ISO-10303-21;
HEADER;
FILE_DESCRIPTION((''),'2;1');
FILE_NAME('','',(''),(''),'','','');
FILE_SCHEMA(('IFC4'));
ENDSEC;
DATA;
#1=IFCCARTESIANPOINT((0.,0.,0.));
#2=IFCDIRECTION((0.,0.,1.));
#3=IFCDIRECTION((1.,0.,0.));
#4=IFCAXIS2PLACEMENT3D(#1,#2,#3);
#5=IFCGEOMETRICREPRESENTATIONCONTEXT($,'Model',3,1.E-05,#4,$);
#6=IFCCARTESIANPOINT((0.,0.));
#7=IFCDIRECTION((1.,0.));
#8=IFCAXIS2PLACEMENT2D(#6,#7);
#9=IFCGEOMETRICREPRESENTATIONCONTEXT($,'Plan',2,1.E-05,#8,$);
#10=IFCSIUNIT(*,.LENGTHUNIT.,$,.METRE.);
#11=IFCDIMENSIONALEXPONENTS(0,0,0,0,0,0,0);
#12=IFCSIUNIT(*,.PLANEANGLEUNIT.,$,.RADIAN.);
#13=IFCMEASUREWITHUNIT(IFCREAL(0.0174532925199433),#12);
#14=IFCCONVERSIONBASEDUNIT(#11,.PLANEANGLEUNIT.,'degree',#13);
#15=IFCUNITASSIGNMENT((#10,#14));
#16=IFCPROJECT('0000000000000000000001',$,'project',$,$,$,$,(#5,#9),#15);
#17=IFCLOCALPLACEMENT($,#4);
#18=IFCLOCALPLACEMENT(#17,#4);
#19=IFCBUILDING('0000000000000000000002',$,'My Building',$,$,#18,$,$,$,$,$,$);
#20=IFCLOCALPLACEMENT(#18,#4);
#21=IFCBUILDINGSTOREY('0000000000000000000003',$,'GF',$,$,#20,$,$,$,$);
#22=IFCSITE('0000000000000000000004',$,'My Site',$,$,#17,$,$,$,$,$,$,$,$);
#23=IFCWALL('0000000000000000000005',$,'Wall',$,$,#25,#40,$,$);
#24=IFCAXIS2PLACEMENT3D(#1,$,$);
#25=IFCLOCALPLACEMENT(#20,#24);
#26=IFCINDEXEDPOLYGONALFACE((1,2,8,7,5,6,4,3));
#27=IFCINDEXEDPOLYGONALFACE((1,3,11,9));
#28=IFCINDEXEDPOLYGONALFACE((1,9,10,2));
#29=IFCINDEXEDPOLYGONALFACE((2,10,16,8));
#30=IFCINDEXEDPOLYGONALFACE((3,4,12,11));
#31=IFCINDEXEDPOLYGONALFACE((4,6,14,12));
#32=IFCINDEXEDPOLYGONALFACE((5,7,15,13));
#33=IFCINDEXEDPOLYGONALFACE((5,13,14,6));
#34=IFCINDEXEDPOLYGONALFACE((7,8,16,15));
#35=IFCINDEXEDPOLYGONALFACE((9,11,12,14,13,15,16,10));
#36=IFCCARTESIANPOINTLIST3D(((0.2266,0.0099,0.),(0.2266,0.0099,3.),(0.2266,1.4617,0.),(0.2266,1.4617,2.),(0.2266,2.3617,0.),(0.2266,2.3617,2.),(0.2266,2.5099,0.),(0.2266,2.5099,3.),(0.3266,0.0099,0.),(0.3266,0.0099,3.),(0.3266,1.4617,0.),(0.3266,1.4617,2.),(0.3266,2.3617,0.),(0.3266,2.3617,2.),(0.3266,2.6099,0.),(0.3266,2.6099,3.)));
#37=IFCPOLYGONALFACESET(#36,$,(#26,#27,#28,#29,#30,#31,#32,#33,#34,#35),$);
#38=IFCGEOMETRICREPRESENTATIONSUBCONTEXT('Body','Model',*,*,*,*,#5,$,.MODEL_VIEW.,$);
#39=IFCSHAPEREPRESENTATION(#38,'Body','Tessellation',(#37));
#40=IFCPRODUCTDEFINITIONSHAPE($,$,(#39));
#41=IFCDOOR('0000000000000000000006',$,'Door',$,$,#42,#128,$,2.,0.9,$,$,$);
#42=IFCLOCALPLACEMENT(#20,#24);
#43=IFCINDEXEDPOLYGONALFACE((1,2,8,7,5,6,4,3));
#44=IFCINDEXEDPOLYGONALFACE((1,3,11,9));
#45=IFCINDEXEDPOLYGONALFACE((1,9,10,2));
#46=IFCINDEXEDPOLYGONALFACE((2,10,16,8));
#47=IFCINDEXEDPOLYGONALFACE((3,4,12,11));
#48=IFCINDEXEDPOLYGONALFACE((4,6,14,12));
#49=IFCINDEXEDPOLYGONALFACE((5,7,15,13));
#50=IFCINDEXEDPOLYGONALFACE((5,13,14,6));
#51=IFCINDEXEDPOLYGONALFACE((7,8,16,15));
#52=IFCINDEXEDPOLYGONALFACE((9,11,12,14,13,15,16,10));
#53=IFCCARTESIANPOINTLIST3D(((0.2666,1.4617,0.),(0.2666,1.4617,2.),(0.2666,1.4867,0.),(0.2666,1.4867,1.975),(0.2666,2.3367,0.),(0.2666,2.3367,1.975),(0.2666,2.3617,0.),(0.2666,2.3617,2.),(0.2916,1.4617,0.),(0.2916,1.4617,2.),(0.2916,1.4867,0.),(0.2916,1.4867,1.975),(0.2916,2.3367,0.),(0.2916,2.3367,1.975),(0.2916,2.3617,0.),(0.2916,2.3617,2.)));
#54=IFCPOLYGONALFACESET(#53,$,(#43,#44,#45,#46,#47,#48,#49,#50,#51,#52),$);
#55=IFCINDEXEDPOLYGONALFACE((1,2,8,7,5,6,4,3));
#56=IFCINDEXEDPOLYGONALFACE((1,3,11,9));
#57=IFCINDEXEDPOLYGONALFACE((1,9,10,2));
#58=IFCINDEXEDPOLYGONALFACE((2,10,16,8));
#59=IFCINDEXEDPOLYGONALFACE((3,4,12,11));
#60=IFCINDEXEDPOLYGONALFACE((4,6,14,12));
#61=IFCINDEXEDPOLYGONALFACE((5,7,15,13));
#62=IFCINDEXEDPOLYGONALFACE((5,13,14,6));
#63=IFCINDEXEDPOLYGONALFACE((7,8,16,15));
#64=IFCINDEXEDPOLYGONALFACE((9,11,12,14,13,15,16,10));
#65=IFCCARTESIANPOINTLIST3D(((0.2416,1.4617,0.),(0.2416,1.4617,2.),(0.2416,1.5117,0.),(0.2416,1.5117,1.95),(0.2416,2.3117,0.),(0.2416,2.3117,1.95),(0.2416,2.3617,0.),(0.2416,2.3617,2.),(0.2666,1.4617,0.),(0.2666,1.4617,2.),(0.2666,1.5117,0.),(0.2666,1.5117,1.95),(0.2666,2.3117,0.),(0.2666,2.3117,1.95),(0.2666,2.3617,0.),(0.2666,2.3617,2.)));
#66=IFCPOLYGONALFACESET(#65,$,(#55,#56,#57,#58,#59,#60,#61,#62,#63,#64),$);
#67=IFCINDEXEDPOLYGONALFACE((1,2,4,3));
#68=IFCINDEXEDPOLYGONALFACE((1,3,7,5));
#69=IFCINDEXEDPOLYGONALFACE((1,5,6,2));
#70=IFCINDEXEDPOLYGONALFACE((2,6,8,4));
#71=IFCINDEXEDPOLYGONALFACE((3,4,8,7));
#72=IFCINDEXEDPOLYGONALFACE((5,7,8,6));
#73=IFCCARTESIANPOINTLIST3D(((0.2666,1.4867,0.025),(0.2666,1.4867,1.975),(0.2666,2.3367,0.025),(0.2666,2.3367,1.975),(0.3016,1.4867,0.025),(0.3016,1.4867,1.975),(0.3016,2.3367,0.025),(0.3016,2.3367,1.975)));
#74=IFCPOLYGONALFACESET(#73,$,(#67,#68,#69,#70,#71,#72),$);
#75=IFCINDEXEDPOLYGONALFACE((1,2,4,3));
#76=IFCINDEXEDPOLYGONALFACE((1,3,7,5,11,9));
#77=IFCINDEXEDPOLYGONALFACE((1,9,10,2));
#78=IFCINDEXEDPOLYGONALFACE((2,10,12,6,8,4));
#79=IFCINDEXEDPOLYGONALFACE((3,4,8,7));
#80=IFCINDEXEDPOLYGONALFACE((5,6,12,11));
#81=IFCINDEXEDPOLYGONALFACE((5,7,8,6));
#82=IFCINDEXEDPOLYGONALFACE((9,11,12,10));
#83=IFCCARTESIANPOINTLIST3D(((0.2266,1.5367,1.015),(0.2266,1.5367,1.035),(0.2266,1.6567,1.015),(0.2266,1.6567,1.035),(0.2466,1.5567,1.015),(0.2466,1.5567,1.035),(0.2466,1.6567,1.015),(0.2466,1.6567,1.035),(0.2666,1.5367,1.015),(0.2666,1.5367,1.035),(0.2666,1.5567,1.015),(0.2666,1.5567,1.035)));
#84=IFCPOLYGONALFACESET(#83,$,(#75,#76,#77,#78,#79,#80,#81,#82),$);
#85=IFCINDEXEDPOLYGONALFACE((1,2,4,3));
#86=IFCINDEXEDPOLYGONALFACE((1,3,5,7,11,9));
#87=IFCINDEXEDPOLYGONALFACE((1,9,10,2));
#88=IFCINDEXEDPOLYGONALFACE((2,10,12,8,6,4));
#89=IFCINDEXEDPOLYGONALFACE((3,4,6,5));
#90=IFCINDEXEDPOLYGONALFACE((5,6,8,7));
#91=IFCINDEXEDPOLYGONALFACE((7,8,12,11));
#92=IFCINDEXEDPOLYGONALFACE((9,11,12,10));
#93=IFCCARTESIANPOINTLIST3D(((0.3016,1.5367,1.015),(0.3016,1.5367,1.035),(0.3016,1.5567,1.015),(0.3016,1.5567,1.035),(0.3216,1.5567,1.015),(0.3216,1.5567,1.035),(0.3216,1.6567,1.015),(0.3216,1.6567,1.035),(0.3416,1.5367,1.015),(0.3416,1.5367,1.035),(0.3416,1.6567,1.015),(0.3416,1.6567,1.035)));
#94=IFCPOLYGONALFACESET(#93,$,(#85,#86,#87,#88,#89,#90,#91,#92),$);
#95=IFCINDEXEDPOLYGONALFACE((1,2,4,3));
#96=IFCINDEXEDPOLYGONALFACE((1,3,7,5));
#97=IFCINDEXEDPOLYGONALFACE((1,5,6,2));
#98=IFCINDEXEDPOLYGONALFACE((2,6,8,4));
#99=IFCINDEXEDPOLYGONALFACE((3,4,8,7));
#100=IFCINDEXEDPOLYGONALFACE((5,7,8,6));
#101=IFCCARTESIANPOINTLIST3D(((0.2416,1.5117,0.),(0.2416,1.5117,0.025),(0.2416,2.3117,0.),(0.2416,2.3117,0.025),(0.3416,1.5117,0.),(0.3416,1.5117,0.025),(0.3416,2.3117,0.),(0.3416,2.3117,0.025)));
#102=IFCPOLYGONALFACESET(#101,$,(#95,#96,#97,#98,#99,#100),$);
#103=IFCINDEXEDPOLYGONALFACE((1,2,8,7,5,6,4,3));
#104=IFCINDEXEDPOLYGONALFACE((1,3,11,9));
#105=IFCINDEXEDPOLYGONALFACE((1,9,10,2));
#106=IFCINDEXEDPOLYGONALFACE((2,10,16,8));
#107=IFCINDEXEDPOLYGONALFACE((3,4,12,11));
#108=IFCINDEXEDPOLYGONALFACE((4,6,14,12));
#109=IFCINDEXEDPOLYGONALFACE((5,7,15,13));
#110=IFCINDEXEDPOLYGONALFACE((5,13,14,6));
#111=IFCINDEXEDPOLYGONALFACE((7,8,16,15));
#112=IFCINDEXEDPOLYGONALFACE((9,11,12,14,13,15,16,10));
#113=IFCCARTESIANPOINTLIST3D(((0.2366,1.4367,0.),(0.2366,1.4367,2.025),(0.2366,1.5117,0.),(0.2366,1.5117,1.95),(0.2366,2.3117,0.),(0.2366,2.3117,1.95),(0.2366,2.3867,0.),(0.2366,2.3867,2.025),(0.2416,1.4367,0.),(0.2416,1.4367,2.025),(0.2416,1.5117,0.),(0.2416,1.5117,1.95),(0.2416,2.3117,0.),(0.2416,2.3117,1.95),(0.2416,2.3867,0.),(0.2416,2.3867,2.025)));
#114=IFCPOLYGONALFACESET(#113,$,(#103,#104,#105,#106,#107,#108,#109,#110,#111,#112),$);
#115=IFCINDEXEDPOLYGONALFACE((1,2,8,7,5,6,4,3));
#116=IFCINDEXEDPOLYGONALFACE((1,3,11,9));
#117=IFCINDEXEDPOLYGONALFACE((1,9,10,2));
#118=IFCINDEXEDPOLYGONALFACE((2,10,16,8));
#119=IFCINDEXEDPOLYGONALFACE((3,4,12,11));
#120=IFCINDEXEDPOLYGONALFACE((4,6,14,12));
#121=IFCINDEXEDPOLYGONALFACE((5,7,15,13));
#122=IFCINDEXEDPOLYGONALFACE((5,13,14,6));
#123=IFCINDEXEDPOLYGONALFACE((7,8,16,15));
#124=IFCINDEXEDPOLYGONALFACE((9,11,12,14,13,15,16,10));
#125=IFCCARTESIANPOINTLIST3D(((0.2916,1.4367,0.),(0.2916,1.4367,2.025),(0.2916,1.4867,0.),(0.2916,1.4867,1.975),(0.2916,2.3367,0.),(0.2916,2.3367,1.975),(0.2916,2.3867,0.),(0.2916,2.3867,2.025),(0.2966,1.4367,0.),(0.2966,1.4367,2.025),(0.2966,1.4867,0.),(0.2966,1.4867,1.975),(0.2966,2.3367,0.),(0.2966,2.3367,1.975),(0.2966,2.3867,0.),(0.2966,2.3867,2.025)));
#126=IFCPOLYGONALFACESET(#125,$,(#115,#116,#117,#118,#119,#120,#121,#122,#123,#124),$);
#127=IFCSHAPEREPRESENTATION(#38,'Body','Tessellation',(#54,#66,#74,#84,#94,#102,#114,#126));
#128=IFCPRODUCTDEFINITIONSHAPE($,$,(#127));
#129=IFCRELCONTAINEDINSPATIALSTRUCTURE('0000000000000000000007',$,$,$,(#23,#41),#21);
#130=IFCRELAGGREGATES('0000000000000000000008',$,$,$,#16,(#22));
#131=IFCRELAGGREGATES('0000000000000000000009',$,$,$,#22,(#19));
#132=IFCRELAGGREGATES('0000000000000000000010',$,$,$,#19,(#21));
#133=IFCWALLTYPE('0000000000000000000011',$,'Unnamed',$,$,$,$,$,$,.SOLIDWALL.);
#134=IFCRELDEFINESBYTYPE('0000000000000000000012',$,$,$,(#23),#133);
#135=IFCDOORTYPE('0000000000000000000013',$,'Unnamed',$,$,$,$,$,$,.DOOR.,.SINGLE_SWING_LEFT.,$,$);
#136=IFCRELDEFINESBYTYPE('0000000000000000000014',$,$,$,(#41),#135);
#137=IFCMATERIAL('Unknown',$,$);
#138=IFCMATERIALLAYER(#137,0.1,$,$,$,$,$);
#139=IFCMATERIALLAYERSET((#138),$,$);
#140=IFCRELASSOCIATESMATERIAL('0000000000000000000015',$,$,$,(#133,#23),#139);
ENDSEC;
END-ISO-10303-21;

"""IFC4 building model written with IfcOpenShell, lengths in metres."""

from ifc_helpers import new_model, entity, si_unit, converted_unit, frame, origin_with_axes, origin_2d_with_axis, place, context, subcontext, project, spatial, line, indexed_curve, outline, extrude, shape, source, transform, mapped, material, layer, layer_set, layer_usage, type_object, type_shapes, element, fill, save


model = new_model("IFC4")

# Units and contexts
model_context = context("Model", 3, precision=1e-05, world=origin_with_axes())
plan_context = context("Plan", 2, precision=1e-05, world=origin_2d_with_axis())
body_context_1 = subcontext(model_context, "Body", "Model", "MODEL_VIEW")
body_context_2 = subcontext(plan_context, "Body", "Plan", "PLAN_VIEW")
ifc_project = project(units=[si_unit("LENGTHUNIT", "METRE"), converted_unit("PLANEANGLEUNIT", "degree", entity("IfcReal", 0.0174532925199433), si_unit("PLANEANGLEUNIT", "RADIAN"), dimensions=[0, 0, 0, 0, 0, 0, 0])], contexts=[model_context, plan_context])

# Site, building, storey
site_placement = place(None, origin_with_axes())
site = spatial("IfcSite", under=ifc_project, at=site_placement, Name="My Site")
building_placement = place(site_placement, origin_with_axes())
building = spatial("IfcBuilding", under=site, at=building_placement, Name="My Building")
storey_placement = place(building_placement, origin_with_axes())
storey = spatial("IfcBuildingStorey", under=building, at=storey_placement, Name="GF")

# Shared definitions
ifc_material_1 = material(Name="Unknown")

# Shared definitions
ifc_layer_1 = layer(ifc_material_1, 0.1)
ifc_layer_set_1 = layer_set([ifc_layer_1])
wall_type = type_object("IfcWallType", Name="Unnamed", PredefinedType="SOLIDWALL", material=ifc_layer_set_1)
shared_shape_1 = source(origin_with_axes(), body_context_1, "Body", "SweptSolid", [
    extrude(outline(indexed_curve([(0.0, 0.0), (0.9, 0.0), (0.9, 2.0), (0.0, 2.0)], segments=[line(1, 2, 3, 4, 1)])), frame((0.0, -0.6, 0.0), z_axis=(0.0, -1.0, 0.0), x_axis=(1.0, 0.0, 0.0)), (0.0, 0.0, -1.0), 1.2),
])
door_type_1 = type_object("IfcDoorType", Name="Unnamed", OperationType="SINGLE_SWING_LEFT", PredefinedType="DOOR")
shared_shape_2 = source(origin_with_axes(), body_context_1, "Body", "SweptSolid", [
    extrude(outline(indexed_curve([(0.0, 0.0), (0.0, 2.0), (0.9, 2.0), (0.9, 0.0), (0.875, 0.0), (0.875, 1.975), (0.025, 1.975), (0.025, 0.0)], segments=[line(1, 2, 3, 4, 5, 6, 7, 8, 1)])), frame((0.0, 0.025, 0.0), z_axis=(0.0, -1.0, 0.0), x_axis=(1.0, 0.0, 0.0)), (0.0, 0.0, -1.0), 0.025),
    extrude(outline(indexed_curve([(0.0, 0.0), (0.0, 2.0), (0.9, 2.0), (0.9, 0.0), (0.85, 0.0), (0.85, 1.95), (0.05, 1.95), (0.05, 0.0)], segments=[line(1, 2, 3, 4, 5, 6, 7, 8, 1)])), frame((0.0, 0.0, 0.0), z_axis=(0.0, -1.0, 0.0), x_axis=(1.0, 0.0, 0.0)), (0.0, 0.0, -1.0), 0.025),
    extrude(outline(indexed_curve([(0.0, 0.0), (0.85, 0.0), (0.85, 0.035), (0.0, 0.035)], segments=[line(1, 2, 3, 4, 1)])), frame((0.025, 0.025, 0.025), z_axis=(0.0, 0.0, 1.0), x_axis=(1.0, 0.0, 0.0)), (0.0, 0.0, 1.0), 1.95),
    extrude(outline(indexed_curve([(0.0, 0.0), (0.0, -0.04), (-0.12, -0.04), (-0.12, -0.02), (-0.02, -0.02), (-0.02, 0.0)], segments=[line(1, 2, 3, 4, 5, 6, 1)])), frame((0.825, 0.025, 1.015), z_axis=(0.0, 0.0, 1.0), x_axis=(1.0, 0.0, 0.0)), (0.0, 0.0, 1.0), 0.02),
    extrude(outline(indexed_curve([(0.0, 0.0), (0.0, 0.04), (-0.12, 0.04), (-0.12, 0.02), (-0.02, 0.02), (-0.02, 0.0)], segments=[line(1, 2, 3, 4, 5, 6, 1)])), frame((0.825, 0.06, 1.015), z_axis=(0.0, 0.0, 1.0), x_axis=(1.0, 0.0, 0.0)), (0.0, 0.0, 1.0), 0.02),
    extrude(outline(indexed_curve([(0.0, 0.0), (0.8, 0.0), (0.8, 0.1), (0.0, 0.1)], segments=[line(1, 2, 3, 4, 1)])), frame((0.05, 0.0, 0.0), z_axis=(0.0, 0.0, 1.0), x_axis=(1.0, 0.0, 0.0)), (0.0, 0.0, 1.0), 0.025),
    extrude(outline(indexed_curve([(0.0, 0.0), (0.0, 2.025), (0.95, 2.025), (0.95, 0.0), (0.875, 0.0), (0.875, 1.95), (0.075, 1.95), (0.075, 0.0)], segments=[line(1, 2, 3, 4, 5, 6, 7, 8, 1)])), frame((-0.025, -0.005, 0.0), z_axis=(0.0, -1.0, 0.0), x_axis=(1.0, 0.0, 0.0)), (0.0, 0.0, -1.0), 0.005),
    extrude(outline(indexed_curve([(0.0, 0.0), (0.0, 2.025), (0.95, 2.025), (0.95, 0.0), (0.9, 0.0), (0.9, 1.975), (0.05, 1.975), (0.05, 0.0)], segments=[line(1, 2, 3, 4, 5, 6, 7, 8, 1)])), frame((-0.025, 0.05, 0.0), z_axis=(0.0, -1.0, 0.0), x_axis=(1.0, 0.0, 0.0)), (0.0, 0.0, -1.0), 0.005),
])
shared_shape_3 = source(origin_with_axes(), body_context_2, "Body", "Curve2D", [
    entity("IfcIndexedPolyCurve", entity("IfcCartesianPointList2D", [[0.0, 0.0], [0.0, 0.05], [0.025, 0.05], [0.025, 0.025], [0.05, 0.025], [0.05, 0.0]]), [entity("IfcLineIndex", [1, 2, 3, 4, 5, 6, 1])]),
    entity("IfcIndexedPolyCurve", entity("IfcCartesianPointList2D", [[0.9, 0.0], [0.9, 0.05], [0.875, 0.05], [0.875, 0.025], [0.85, 0.025], [0.85, 0.0]]), [entity("IfcLineIndex", [1, 2, 3, 4, 5, 6, 1])]),
    entity("IfcTrimmedCurve", entity("IfcEllipse", entity("IfcAxis2Placement2D", entity("IfcCartesianPoint", [0.06, 0.05]), entity("IfcDirection", [1.0, 0.0])), 0.815, 0.85), [entity("IfcCartesianPoint", [0.875, 0.05])], [entity("IfcCartesianPoint", [0.06, 0.9])], True, "CARTESIAN"),
    entity("IfcIndexedPolyCurve", entity("IfcCartesianPointList2D", [[0.025, 0.05], [0.06, 0.05], [0.06, 0.9], [0.025, 0.9]]), [entity("IfcLineIndex", [1, 2, 3, 4, 1])]),
])
type_shapes(door_type_1, [shared_shape_2, shared_shape_3])

# Wall, opening, door
ifc_layer_usage_1 = layer_usage(ifc_layer_set_1, "AXIS2", "POSITIVE", 0.0)
wall_1_placement = place(storey_placement, frame((0.3266, 0.0099, 0.0), z_axis=(0.0, 0.0, 1.0), x_axis=(0.0, 1.0, 0.0)))
wall_1 = element("IfcWall", 1, at=wall_1_placement, inside=storey, type_object=wall_type, material=ifc_layer_usage_1, Name="Wall", context=body_context_1, shape_type="SweptSolid", body=[
    extrude(outline(indexed_curve([(0.0, 0.0), (0.0, 0.1), (2.5, 0.1), (2.6, 0.0)], segments=[line(1, 2, 3, 4, 1)])), origin_with_axes(), (0.0, 0.0, 1.0), 3.0),
])
opening_1_placement = place(wall_1_placement, frame((1.4518, 0.0, 0.0), z_axis=(0.0, 0.0, 1.0), x_axis=(1.0, 0.0, 0.0)))
opening_1 = element("IfcOpeningElement", 2, at=opening_1_placement, cuts=wall_1, PredefinedType="OPENING", context=body_context_1, shape_type="MappedRepresentation", body=[
    mapped(shared_shape_1, transform((0.0, 0.0, 0.0), x_axis=(1.0, 0.0, 0.0), y_axis=(0.0, 1.0, 0.0), z_axis=(0.0, 0.0, 1.0), scale=1.0)),
])
door_1_placement = place(opening_1_placement, frame((0.9, 0.085, 0.0), z_axis=(0.0, 0.0, 1.0), x_axis=(-1.0, 0.0, 0.0)))
door_1 = element("IfcDoor", 3, at=door_1_placement, inside=storey, type_object=door_type_1, Name="Door", OverallHeight=2.0, OverallWidth=0.9, shapes=[
    shape(body_context_1, "Body", "MappedRepresentation", [mapped(shared_shape_2, transform((0.0, 0.0, 0.0), x_axis=(1.0, 0.0, 0.0), y_axis=(0.0, 1.0, 0.0), z_axis=(0.0, 0.0, 1.0), scale=1.0))]),
    shape(body_context_2, "Body", "MappedRepresentation", [mapped(shared_shape_3, transform((0.0, 0.0, 0.0), x_axis=(1.0, 0.0, 0.0), y_axis=(0.0, 1.0, 0.0), z_axis=(0.0, 0.0, 1.0), scale=1.0))]),
])
fill(opening_1, door_1)

save(model, "model.ifc")
